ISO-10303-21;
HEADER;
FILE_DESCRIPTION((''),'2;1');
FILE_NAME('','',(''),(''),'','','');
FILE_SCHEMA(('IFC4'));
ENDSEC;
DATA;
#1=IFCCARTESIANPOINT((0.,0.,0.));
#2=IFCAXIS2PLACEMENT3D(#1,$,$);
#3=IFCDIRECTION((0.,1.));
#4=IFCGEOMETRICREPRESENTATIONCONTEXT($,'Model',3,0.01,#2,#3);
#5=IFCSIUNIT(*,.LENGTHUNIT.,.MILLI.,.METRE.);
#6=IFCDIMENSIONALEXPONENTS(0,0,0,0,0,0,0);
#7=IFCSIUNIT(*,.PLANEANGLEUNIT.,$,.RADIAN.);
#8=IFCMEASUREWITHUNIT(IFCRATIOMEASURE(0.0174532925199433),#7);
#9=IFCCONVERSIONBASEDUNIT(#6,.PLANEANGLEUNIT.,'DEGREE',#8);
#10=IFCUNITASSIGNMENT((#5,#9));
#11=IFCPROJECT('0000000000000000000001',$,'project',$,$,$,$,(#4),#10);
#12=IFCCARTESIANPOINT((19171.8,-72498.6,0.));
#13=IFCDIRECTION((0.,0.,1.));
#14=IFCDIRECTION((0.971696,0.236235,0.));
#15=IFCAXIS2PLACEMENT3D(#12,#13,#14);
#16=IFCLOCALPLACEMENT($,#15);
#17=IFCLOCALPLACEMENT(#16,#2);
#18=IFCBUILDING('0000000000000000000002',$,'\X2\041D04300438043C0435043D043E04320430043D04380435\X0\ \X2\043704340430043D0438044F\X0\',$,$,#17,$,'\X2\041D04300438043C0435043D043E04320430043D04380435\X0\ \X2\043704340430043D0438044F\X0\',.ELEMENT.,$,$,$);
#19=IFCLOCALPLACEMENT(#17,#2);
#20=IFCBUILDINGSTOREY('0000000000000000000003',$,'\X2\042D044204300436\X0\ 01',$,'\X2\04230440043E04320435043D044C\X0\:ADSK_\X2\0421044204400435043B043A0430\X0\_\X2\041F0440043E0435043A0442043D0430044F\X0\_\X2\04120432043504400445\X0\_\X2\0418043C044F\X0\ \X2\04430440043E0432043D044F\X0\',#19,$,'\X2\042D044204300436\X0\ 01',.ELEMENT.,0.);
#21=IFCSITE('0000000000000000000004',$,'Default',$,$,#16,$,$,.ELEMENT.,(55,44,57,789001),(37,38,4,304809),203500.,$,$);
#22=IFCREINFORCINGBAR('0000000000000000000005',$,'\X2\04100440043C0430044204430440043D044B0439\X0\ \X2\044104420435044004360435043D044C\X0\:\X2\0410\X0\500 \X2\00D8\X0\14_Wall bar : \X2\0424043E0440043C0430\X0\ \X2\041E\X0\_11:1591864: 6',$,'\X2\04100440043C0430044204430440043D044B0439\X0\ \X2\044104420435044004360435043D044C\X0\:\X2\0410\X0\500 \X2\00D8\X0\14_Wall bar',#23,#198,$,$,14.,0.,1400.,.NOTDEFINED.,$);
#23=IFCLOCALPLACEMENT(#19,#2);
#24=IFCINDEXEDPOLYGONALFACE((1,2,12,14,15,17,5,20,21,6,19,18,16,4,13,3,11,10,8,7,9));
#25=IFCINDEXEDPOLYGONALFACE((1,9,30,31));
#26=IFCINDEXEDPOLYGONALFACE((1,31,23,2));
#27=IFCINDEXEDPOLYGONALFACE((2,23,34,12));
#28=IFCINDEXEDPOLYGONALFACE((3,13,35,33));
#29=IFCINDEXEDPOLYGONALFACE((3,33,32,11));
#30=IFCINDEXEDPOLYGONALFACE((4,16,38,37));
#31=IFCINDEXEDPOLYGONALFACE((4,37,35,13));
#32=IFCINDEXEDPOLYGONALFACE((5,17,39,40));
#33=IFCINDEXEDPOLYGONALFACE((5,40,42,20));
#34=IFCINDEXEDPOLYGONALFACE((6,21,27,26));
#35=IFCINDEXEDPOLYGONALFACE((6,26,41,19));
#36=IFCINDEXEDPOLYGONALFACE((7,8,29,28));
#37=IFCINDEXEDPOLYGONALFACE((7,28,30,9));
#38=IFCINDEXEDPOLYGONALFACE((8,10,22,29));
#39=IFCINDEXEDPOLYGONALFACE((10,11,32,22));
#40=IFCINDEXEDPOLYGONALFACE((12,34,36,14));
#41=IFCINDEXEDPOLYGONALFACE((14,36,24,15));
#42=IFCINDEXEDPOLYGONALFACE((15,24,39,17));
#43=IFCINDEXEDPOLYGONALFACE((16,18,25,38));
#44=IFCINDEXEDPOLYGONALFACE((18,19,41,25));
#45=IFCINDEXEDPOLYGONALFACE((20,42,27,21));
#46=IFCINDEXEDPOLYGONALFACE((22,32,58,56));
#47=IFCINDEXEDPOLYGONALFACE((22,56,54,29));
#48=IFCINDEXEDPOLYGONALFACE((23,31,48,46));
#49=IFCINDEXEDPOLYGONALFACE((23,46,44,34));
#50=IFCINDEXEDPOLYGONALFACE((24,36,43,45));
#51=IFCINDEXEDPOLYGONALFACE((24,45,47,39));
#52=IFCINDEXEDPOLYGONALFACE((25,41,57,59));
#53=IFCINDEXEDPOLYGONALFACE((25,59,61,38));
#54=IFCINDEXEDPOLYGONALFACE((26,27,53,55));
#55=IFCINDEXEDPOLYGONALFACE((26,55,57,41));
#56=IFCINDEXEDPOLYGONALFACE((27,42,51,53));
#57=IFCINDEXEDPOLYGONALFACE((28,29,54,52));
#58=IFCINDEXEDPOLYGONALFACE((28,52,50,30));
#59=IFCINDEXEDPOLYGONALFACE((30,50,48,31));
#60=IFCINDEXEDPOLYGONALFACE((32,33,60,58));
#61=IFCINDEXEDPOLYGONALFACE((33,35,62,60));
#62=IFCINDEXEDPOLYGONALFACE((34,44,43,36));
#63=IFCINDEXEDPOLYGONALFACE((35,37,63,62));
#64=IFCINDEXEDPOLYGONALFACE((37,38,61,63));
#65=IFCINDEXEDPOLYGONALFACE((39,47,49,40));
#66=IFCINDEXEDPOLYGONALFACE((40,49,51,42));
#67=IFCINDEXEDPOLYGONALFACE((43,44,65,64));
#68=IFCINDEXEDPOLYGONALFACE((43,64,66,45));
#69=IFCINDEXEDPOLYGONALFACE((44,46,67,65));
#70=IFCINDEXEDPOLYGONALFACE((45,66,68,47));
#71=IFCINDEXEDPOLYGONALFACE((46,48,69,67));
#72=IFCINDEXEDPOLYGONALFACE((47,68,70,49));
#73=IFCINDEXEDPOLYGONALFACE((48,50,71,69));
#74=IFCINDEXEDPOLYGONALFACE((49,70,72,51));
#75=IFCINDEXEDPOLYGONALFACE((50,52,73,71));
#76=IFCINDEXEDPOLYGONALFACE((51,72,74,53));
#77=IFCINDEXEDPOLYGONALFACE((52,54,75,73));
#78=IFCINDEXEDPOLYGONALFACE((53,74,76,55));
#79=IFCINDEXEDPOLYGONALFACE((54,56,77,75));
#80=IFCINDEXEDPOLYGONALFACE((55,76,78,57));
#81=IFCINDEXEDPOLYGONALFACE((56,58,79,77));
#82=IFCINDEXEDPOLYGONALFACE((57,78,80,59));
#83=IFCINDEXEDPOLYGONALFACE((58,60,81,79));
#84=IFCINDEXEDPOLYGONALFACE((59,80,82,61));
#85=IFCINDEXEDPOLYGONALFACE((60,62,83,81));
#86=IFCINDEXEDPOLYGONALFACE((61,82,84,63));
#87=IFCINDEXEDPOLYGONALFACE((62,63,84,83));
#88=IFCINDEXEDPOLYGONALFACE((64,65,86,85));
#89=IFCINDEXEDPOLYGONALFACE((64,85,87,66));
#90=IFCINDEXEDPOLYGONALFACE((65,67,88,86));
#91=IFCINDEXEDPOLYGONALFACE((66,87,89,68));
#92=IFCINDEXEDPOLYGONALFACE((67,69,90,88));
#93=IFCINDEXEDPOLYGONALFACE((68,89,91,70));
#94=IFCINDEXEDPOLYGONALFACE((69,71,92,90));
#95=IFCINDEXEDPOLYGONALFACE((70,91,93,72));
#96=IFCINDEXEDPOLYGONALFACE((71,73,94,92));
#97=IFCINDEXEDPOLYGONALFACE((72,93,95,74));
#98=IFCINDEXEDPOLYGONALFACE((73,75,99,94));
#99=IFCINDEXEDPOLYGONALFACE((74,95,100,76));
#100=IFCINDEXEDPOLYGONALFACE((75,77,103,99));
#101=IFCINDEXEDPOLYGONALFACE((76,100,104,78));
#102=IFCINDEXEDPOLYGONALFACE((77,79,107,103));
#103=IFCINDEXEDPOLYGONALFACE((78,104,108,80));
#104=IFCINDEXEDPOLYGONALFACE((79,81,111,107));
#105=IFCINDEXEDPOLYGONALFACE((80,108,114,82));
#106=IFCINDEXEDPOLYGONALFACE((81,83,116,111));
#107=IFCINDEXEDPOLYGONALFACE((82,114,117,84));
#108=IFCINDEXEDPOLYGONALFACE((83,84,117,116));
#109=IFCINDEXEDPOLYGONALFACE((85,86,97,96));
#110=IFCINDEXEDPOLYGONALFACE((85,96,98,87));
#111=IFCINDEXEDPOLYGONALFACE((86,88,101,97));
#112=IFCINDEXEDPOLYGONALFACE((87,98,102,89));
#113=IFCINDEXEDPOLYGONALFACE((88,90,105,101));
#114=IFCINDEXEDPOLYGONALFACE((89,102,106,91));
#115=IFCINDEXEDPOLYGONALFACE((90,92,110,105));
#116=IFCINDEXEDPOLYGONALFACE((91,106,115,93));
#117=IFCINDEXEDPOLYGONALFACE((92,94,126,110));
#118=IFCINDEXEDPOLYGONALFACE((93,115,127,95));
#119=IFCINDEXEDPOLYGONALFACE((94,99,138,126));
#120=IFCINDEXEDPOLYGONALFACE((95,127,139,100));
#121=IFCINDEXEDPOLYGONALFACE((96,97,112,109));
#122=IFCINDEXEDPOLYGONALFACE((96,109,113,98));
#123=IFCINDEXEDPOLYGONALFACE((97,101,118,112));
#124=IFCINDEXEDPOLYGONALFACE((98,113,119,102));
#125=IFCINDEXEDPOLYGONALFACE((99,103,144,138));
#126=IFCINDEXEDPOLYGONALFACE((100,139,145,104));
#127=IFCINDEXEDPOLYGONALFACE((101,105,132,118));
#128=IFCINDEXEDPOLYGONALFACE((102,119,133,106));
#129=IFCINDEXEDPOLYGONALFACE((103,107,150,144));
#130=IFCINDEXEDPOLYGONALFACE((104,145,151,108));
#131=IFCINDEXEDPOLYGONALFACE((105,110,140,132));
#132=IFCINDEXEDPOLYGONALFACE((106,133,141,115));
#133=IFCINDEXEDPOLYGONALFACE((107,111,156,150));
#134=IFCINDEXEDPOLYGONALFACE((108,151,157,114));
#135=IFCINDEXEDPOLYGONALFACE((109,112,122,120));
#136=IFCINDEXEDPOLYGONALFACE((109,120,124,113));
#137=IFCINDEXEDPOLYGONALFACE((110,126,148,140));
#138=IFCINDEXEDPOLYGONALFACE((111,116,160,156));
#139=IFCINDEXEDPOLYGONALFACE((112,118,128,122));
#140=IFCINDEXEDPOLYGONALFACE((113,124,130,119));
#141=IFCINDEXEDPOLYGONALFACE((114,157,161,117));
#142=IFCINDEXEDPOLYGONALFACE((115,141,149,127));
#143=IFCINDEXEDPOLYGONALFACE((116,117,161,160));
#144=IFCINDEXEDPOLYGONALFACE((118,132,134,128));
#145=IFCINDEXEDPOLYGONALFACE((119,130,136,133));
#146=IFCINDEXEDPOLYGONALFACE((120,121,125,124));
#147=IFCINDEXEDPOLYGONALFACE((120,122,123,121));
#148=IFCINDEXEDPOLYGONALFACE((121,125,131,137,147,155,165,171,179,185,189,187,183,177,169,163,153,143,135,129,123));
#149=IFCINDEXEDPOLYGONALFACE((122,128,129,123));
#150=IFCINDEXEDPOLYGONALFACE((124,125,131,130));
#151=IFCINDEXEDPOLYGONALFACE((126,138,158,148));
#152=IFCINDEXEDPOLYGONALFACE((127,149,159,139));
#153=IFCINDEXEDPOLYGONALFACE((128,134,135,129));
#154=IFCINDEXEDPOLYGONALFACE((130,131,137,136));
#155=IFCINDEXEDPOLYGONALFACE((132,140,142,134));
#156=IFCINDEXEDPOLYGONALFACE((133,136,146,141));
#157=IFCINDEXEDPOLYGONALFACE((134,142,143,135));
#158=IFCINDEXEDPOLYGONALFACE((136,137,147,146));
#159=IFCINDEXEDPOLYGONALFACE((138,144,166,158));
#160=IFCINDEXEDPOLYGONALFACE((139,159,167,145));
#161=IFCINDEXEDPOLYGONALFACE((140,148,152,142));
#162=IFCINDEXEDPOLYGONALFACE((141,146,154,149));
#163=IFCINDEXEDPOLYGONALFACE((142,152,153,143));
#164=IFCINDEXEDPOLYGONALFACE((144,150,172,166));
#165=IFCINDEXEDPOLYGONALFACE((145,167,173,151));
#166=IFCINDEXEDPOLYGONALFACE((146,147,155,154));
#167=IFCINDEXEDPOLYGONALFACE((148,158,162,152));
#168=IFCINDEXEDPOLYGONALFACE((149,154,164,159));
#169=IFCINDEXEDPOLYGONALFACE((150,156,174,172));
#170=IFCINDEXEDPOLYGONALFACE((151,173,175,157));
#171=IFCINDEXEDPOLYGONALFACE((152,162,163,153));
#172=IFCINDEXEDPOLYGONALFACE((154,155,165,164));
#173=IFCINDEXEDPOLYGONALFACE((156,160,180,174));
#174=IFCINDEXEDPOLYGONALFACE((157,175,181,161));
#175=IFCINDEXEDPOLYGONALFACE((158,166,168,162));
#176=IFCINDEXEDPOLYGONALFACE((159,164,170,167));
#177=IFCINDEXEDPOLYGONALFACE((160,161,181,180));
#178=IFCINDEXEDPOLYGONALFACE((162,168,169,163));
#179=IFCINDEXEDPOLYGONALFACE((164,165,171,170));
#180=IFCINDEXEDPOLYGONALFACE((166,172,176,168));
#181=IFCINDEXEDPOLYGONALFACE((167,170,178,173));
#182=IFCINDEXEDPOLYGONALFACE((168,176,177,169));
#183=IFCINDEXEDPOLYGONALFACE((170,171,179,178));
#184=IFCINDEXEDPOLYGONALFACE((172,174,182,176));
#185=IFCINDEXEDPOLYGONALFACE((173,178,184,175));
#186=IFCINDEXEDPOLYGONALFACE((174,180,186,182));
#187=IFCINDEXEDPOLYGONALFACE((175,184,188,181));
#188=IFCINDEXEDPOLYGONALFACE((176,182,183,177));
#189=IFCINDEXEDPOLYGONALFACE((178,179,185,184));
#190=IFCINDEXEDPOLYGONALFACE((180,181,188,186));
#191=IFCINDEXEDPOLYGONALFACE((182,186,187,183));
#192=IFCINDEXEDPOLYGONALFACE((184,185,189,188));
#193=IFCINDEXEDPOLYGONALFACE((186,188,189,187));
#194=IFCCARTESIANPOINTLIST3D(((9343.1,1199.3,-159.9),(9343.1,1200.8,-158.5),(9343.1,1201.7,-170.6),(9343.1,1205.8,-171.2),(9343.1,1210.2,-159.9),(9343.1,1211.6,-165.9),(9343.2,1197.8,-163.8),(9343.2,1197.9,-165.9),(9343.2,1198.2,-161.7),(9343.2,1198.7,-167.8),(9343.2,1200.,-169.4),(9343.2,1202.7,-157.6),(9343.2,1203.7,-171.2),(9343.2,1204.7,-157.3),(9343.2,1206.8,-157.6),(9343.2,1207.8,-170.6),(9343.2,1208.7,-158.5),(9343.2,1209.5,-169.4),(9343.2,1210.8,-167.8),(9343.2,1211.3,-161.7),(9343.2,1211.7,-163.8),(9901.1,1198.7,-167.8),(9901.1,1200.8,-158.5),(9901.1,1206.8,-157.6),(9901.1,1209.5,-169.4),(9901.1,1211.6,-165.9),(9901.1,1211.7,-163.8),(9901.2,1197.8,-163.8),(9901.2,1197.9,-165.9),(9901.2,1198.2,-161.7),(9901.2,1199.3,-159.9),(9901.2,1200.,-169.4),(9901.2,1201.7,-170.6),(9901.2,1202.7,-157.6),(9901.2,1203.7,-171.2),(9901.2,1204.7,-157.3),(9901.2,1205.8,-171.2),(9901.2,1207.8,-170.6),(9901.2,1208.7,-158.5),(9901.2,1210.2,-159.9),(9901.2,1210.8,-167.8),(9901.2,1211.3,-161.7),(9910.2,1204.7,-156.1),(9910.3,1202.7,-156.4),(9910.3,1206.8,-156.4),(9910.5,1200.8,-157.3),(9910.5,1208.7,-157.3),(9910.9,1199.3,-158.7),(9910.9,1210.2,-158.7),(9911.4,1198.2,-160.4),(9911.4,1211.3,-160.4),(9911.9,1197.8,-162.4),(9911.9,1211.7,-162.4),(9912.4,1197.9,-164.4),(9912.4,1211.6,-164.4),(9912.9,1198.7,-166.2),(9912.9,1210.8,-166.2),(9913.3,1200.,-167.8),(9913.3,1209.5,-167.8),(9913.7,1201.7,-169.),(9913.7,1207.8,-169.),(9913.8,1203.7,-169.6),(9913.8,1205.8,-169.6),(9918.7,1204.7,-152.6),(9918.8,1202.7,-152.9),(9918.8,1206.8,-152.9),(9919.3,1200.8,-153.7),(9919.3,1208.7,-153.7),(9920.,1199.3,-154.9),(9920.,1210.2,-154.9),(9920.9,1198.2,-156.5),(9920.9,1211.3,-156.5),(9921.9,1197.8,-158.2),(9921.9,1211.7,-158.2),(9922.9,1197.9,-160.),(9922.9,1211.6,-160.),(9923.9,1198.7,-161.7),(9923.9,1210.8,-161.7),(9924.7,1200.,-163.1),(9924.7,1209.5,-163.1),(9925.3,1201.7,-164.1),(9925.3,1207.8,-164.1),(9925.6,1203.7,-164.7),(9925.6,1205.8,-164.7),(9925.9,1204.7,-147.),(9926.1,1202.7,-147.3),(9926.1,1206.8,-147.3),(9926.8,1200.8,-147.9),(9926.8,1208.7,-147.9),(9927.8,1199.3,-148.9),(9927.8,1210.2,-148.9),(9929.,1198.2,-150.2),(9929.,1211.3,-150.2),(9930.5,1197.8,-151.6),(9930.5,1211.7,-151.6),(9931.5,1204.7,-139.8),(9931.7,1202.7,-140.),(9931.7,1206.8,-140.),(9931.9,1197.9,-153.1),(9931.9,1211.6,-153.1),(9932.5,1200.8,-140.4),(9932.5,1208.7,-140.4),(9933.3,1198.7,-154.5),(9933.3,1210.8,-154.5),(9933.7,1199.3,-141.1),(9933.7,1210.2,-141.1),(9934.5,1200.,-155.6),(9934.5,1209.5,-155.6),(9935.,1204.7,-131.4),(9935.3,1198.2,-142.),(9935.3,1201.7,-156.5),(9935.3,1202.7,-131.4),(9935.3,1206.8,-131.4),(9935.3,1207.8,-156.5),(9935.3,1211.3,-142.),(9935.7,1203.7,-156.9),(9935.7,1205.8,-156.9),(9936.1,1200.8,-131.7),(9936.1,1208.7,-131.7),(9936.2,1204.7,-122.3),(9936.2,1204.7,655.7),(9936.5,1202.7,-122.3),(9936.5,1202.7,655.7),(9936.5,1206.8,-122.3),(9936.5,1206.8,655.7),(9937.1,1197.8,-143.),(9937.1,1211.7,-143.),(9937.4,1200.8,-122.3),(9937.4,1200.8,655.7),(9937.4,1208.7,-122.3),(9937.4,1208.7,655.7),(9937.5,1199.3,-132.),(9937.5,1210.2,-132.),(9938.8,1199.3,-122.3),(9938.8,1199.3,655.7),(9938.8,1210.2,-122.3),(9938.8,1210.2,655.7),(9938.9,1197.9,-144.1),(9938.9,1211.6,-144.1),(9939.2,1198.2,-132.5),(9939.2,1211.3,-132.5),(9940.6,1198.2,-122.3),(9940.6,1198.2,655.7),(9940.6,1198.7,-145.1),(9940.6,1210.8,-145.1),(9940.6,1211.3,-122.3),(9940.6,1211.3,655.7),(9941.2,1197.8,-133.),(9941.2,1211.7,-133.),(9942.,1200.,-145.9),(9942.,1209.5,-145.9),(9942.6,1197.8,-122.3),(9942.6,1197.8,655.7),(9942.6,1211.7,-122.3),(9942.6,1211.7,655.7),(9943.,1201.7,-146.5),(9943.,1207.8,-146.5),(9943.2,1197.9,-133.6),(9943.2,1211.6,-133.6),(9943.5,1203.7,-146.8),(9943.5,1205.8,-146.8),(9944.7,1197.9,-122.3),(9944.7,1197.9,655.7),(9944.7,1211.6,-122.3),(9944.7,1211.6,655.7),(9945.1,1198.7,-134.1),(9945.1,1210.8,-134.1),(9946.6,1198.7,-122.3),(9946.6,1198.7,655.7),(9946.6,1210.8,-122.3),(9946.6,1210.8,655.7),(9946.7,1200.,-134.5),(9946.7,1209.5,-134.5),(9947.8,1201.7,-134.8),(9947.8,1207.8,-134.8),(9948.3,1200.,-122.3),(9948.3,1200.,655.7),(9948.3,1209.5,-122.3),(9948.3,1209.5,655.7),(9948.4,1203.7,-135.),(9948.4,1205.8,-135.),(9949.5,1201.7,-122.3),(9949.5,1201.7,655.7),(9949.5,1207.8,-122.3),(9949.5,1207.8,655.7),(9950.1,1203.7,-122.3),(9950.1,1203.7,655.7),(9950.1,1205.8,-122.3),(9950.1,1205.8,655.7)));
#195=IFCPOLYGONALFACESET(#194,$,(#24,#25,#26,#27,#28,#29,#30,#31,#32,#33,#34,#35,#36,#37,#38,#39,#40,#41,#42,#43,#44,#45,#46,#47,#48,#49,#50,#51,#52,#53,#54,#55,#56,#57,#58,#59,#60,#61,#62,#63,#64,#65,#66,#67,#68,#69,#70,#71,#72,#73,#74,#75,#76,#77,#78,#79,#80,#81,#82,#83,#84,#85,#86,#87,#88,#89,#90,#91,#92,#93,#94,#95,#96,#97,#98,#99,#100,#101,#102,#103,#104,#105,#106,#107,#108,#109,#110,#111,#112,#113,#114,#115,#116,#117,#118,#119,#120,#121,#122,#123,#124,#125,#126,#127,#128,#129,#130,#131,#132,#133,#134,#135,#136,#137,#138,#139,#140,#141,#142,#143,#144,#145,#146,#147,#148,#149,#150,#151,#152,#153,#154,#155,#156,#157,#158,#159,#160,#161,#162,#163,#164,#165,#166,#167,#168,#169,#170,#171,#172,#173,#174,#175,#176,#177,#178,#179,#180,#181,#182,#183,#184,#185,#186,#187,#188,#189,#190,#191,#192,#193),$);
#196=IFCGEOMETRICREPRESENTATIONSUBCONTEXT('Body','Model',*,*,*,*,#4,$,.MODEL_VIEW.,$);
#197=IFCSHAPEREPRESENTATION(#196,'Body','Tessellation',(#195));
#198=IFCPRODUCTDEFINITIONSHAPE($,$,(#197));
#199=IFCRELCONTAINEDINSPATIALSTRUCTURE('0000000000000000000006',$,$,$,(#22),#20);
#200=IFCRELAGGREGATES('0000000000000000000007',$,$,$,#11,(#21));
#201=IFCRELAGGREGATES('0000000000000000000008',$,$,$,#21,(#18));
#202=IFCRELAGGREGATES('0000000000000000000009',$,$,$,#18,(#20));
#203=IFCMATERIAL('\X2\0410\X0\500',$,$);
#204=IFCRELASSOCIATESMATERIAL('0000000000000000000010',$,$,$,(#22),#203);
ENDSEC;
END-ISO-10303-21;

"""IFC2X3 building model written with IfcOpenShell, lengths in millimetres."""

from ifc_helpers import new_model, entity, si_unit, converted_unit, direction, frame, origin, place, context, subcontext, project, spatial, material, element, save


model = new_model("IFC2X3")

# Units and contexts
model_context = context("Model", 3, precision=0.01, world=origin(), true_north=direction((0.0, 1.0)))
body_context = subcontext(model_context, "Body", "Model", "MODEL_VIEW")
ifc_project = project(units=[si_unit("LENGTHUNIT", "METRE", prefix="MILLI"), converted_unit("PLANEANGLEUNIT", "DEGREE", entity("IfcRatioMeasure", 0.0174532925199433), si_unit("PLANEANGLEUNIT", "RADIAN"), dimensions=[0, 0, 0, 0, 0, 0, 0])], contexts=[model_context])

# Site, building, storey
site_placement = place(None, frame((19171.8, -72498.6, 0.0), z_axis=(0.0, 0.0, 1.0), x_axis=(0.971696, 0.236235, 0.0)))
site = spatial("IfcSite", under=ifc_project, at=site_placement, Name="Default", CompositionType="ELEMENT", RefLatitude=(55, 44, 57, 789001), RefLongitude=(37, 38, 4, 304809), RefElevation=203500.0)
building_placement = place(site_placement, origin())
building = spatial("IfcBuilding", under=site, at=building_placement, Name="Наименование здания", LongName="Наименование здания", CompositionType="ELEMENT")
storey_placement = place(building_placement, origin())
storey = spatial("IfcBuildingStorey", under=building, at=storey_placement, Name="Этаж 01", ObjectType="Уровень:ADSK_Стрелка_Проектная_Вверх_Имя уровня", LongName="Этаж 01", CompositionType="ELEMENT", Elevation=0.0)

# Reinforcing bar
ifc_material = material(Name="А500")
placement = place(storey_placement, origin())
element("IfcReinforcingBar", 1, at=placement, inside=storey, material=ifc_material, Name="Арматурный стержень:А500 Ø14_Wall bar : Форма О_11:1591864: 6", ObjectType="Арматурный стержень:А500 Ø14_Wall bar", BarLength=1400.0, BarRole="NOTDEFINED", CrossSectionArea=0.0, NominalDiameter=14.0, context=body_context, shape_type="AdvancedSweptSolid", body=[
    entity("IfcSweptDiskSolid", entity("IfcCompositeCurve", [entity("IfcCompositeCurveSegment", "CONTINUOUS", True, entity("IfcPolyline", [entity("IfcCartesianPoint", [9943.1, 1204.7, 655.7]), entity("IfcCartesianPoint", [9943.1, 1204.7, -122.3])])), entity("IfcCompositeCurveSegment", "CONTINUOUS", True, entity("IfcTrimmedCurve", entity("IfcCircle", entity("IfcAxis2Placement3D", entity("IfcCartesianPoint", [9901.1, 1204.7, -122.3]), entity("IfcDirection", [0.0, 1.0, 0.0]), entity("IfcDirection", [0.0, 0.0, -1.0])), 42.0), [entity("IfcParameterValue", 270.0)], [entity("IfcParameterValue", 360.0)], True, "PARAMETER")), entity("IfcCompositeCurveSegment", "CONTINUOUS", True, entity("IfcPolyline", [entity("IfcCartesianPoint", [9901.1, 1204.7, -164.3]), entity("IfcCartesianPoint", [9343.1, 1204.7, -164.3])]))], False), 7.0, None, 0.0, 92.0),
])

save(model, "model.ifc")
